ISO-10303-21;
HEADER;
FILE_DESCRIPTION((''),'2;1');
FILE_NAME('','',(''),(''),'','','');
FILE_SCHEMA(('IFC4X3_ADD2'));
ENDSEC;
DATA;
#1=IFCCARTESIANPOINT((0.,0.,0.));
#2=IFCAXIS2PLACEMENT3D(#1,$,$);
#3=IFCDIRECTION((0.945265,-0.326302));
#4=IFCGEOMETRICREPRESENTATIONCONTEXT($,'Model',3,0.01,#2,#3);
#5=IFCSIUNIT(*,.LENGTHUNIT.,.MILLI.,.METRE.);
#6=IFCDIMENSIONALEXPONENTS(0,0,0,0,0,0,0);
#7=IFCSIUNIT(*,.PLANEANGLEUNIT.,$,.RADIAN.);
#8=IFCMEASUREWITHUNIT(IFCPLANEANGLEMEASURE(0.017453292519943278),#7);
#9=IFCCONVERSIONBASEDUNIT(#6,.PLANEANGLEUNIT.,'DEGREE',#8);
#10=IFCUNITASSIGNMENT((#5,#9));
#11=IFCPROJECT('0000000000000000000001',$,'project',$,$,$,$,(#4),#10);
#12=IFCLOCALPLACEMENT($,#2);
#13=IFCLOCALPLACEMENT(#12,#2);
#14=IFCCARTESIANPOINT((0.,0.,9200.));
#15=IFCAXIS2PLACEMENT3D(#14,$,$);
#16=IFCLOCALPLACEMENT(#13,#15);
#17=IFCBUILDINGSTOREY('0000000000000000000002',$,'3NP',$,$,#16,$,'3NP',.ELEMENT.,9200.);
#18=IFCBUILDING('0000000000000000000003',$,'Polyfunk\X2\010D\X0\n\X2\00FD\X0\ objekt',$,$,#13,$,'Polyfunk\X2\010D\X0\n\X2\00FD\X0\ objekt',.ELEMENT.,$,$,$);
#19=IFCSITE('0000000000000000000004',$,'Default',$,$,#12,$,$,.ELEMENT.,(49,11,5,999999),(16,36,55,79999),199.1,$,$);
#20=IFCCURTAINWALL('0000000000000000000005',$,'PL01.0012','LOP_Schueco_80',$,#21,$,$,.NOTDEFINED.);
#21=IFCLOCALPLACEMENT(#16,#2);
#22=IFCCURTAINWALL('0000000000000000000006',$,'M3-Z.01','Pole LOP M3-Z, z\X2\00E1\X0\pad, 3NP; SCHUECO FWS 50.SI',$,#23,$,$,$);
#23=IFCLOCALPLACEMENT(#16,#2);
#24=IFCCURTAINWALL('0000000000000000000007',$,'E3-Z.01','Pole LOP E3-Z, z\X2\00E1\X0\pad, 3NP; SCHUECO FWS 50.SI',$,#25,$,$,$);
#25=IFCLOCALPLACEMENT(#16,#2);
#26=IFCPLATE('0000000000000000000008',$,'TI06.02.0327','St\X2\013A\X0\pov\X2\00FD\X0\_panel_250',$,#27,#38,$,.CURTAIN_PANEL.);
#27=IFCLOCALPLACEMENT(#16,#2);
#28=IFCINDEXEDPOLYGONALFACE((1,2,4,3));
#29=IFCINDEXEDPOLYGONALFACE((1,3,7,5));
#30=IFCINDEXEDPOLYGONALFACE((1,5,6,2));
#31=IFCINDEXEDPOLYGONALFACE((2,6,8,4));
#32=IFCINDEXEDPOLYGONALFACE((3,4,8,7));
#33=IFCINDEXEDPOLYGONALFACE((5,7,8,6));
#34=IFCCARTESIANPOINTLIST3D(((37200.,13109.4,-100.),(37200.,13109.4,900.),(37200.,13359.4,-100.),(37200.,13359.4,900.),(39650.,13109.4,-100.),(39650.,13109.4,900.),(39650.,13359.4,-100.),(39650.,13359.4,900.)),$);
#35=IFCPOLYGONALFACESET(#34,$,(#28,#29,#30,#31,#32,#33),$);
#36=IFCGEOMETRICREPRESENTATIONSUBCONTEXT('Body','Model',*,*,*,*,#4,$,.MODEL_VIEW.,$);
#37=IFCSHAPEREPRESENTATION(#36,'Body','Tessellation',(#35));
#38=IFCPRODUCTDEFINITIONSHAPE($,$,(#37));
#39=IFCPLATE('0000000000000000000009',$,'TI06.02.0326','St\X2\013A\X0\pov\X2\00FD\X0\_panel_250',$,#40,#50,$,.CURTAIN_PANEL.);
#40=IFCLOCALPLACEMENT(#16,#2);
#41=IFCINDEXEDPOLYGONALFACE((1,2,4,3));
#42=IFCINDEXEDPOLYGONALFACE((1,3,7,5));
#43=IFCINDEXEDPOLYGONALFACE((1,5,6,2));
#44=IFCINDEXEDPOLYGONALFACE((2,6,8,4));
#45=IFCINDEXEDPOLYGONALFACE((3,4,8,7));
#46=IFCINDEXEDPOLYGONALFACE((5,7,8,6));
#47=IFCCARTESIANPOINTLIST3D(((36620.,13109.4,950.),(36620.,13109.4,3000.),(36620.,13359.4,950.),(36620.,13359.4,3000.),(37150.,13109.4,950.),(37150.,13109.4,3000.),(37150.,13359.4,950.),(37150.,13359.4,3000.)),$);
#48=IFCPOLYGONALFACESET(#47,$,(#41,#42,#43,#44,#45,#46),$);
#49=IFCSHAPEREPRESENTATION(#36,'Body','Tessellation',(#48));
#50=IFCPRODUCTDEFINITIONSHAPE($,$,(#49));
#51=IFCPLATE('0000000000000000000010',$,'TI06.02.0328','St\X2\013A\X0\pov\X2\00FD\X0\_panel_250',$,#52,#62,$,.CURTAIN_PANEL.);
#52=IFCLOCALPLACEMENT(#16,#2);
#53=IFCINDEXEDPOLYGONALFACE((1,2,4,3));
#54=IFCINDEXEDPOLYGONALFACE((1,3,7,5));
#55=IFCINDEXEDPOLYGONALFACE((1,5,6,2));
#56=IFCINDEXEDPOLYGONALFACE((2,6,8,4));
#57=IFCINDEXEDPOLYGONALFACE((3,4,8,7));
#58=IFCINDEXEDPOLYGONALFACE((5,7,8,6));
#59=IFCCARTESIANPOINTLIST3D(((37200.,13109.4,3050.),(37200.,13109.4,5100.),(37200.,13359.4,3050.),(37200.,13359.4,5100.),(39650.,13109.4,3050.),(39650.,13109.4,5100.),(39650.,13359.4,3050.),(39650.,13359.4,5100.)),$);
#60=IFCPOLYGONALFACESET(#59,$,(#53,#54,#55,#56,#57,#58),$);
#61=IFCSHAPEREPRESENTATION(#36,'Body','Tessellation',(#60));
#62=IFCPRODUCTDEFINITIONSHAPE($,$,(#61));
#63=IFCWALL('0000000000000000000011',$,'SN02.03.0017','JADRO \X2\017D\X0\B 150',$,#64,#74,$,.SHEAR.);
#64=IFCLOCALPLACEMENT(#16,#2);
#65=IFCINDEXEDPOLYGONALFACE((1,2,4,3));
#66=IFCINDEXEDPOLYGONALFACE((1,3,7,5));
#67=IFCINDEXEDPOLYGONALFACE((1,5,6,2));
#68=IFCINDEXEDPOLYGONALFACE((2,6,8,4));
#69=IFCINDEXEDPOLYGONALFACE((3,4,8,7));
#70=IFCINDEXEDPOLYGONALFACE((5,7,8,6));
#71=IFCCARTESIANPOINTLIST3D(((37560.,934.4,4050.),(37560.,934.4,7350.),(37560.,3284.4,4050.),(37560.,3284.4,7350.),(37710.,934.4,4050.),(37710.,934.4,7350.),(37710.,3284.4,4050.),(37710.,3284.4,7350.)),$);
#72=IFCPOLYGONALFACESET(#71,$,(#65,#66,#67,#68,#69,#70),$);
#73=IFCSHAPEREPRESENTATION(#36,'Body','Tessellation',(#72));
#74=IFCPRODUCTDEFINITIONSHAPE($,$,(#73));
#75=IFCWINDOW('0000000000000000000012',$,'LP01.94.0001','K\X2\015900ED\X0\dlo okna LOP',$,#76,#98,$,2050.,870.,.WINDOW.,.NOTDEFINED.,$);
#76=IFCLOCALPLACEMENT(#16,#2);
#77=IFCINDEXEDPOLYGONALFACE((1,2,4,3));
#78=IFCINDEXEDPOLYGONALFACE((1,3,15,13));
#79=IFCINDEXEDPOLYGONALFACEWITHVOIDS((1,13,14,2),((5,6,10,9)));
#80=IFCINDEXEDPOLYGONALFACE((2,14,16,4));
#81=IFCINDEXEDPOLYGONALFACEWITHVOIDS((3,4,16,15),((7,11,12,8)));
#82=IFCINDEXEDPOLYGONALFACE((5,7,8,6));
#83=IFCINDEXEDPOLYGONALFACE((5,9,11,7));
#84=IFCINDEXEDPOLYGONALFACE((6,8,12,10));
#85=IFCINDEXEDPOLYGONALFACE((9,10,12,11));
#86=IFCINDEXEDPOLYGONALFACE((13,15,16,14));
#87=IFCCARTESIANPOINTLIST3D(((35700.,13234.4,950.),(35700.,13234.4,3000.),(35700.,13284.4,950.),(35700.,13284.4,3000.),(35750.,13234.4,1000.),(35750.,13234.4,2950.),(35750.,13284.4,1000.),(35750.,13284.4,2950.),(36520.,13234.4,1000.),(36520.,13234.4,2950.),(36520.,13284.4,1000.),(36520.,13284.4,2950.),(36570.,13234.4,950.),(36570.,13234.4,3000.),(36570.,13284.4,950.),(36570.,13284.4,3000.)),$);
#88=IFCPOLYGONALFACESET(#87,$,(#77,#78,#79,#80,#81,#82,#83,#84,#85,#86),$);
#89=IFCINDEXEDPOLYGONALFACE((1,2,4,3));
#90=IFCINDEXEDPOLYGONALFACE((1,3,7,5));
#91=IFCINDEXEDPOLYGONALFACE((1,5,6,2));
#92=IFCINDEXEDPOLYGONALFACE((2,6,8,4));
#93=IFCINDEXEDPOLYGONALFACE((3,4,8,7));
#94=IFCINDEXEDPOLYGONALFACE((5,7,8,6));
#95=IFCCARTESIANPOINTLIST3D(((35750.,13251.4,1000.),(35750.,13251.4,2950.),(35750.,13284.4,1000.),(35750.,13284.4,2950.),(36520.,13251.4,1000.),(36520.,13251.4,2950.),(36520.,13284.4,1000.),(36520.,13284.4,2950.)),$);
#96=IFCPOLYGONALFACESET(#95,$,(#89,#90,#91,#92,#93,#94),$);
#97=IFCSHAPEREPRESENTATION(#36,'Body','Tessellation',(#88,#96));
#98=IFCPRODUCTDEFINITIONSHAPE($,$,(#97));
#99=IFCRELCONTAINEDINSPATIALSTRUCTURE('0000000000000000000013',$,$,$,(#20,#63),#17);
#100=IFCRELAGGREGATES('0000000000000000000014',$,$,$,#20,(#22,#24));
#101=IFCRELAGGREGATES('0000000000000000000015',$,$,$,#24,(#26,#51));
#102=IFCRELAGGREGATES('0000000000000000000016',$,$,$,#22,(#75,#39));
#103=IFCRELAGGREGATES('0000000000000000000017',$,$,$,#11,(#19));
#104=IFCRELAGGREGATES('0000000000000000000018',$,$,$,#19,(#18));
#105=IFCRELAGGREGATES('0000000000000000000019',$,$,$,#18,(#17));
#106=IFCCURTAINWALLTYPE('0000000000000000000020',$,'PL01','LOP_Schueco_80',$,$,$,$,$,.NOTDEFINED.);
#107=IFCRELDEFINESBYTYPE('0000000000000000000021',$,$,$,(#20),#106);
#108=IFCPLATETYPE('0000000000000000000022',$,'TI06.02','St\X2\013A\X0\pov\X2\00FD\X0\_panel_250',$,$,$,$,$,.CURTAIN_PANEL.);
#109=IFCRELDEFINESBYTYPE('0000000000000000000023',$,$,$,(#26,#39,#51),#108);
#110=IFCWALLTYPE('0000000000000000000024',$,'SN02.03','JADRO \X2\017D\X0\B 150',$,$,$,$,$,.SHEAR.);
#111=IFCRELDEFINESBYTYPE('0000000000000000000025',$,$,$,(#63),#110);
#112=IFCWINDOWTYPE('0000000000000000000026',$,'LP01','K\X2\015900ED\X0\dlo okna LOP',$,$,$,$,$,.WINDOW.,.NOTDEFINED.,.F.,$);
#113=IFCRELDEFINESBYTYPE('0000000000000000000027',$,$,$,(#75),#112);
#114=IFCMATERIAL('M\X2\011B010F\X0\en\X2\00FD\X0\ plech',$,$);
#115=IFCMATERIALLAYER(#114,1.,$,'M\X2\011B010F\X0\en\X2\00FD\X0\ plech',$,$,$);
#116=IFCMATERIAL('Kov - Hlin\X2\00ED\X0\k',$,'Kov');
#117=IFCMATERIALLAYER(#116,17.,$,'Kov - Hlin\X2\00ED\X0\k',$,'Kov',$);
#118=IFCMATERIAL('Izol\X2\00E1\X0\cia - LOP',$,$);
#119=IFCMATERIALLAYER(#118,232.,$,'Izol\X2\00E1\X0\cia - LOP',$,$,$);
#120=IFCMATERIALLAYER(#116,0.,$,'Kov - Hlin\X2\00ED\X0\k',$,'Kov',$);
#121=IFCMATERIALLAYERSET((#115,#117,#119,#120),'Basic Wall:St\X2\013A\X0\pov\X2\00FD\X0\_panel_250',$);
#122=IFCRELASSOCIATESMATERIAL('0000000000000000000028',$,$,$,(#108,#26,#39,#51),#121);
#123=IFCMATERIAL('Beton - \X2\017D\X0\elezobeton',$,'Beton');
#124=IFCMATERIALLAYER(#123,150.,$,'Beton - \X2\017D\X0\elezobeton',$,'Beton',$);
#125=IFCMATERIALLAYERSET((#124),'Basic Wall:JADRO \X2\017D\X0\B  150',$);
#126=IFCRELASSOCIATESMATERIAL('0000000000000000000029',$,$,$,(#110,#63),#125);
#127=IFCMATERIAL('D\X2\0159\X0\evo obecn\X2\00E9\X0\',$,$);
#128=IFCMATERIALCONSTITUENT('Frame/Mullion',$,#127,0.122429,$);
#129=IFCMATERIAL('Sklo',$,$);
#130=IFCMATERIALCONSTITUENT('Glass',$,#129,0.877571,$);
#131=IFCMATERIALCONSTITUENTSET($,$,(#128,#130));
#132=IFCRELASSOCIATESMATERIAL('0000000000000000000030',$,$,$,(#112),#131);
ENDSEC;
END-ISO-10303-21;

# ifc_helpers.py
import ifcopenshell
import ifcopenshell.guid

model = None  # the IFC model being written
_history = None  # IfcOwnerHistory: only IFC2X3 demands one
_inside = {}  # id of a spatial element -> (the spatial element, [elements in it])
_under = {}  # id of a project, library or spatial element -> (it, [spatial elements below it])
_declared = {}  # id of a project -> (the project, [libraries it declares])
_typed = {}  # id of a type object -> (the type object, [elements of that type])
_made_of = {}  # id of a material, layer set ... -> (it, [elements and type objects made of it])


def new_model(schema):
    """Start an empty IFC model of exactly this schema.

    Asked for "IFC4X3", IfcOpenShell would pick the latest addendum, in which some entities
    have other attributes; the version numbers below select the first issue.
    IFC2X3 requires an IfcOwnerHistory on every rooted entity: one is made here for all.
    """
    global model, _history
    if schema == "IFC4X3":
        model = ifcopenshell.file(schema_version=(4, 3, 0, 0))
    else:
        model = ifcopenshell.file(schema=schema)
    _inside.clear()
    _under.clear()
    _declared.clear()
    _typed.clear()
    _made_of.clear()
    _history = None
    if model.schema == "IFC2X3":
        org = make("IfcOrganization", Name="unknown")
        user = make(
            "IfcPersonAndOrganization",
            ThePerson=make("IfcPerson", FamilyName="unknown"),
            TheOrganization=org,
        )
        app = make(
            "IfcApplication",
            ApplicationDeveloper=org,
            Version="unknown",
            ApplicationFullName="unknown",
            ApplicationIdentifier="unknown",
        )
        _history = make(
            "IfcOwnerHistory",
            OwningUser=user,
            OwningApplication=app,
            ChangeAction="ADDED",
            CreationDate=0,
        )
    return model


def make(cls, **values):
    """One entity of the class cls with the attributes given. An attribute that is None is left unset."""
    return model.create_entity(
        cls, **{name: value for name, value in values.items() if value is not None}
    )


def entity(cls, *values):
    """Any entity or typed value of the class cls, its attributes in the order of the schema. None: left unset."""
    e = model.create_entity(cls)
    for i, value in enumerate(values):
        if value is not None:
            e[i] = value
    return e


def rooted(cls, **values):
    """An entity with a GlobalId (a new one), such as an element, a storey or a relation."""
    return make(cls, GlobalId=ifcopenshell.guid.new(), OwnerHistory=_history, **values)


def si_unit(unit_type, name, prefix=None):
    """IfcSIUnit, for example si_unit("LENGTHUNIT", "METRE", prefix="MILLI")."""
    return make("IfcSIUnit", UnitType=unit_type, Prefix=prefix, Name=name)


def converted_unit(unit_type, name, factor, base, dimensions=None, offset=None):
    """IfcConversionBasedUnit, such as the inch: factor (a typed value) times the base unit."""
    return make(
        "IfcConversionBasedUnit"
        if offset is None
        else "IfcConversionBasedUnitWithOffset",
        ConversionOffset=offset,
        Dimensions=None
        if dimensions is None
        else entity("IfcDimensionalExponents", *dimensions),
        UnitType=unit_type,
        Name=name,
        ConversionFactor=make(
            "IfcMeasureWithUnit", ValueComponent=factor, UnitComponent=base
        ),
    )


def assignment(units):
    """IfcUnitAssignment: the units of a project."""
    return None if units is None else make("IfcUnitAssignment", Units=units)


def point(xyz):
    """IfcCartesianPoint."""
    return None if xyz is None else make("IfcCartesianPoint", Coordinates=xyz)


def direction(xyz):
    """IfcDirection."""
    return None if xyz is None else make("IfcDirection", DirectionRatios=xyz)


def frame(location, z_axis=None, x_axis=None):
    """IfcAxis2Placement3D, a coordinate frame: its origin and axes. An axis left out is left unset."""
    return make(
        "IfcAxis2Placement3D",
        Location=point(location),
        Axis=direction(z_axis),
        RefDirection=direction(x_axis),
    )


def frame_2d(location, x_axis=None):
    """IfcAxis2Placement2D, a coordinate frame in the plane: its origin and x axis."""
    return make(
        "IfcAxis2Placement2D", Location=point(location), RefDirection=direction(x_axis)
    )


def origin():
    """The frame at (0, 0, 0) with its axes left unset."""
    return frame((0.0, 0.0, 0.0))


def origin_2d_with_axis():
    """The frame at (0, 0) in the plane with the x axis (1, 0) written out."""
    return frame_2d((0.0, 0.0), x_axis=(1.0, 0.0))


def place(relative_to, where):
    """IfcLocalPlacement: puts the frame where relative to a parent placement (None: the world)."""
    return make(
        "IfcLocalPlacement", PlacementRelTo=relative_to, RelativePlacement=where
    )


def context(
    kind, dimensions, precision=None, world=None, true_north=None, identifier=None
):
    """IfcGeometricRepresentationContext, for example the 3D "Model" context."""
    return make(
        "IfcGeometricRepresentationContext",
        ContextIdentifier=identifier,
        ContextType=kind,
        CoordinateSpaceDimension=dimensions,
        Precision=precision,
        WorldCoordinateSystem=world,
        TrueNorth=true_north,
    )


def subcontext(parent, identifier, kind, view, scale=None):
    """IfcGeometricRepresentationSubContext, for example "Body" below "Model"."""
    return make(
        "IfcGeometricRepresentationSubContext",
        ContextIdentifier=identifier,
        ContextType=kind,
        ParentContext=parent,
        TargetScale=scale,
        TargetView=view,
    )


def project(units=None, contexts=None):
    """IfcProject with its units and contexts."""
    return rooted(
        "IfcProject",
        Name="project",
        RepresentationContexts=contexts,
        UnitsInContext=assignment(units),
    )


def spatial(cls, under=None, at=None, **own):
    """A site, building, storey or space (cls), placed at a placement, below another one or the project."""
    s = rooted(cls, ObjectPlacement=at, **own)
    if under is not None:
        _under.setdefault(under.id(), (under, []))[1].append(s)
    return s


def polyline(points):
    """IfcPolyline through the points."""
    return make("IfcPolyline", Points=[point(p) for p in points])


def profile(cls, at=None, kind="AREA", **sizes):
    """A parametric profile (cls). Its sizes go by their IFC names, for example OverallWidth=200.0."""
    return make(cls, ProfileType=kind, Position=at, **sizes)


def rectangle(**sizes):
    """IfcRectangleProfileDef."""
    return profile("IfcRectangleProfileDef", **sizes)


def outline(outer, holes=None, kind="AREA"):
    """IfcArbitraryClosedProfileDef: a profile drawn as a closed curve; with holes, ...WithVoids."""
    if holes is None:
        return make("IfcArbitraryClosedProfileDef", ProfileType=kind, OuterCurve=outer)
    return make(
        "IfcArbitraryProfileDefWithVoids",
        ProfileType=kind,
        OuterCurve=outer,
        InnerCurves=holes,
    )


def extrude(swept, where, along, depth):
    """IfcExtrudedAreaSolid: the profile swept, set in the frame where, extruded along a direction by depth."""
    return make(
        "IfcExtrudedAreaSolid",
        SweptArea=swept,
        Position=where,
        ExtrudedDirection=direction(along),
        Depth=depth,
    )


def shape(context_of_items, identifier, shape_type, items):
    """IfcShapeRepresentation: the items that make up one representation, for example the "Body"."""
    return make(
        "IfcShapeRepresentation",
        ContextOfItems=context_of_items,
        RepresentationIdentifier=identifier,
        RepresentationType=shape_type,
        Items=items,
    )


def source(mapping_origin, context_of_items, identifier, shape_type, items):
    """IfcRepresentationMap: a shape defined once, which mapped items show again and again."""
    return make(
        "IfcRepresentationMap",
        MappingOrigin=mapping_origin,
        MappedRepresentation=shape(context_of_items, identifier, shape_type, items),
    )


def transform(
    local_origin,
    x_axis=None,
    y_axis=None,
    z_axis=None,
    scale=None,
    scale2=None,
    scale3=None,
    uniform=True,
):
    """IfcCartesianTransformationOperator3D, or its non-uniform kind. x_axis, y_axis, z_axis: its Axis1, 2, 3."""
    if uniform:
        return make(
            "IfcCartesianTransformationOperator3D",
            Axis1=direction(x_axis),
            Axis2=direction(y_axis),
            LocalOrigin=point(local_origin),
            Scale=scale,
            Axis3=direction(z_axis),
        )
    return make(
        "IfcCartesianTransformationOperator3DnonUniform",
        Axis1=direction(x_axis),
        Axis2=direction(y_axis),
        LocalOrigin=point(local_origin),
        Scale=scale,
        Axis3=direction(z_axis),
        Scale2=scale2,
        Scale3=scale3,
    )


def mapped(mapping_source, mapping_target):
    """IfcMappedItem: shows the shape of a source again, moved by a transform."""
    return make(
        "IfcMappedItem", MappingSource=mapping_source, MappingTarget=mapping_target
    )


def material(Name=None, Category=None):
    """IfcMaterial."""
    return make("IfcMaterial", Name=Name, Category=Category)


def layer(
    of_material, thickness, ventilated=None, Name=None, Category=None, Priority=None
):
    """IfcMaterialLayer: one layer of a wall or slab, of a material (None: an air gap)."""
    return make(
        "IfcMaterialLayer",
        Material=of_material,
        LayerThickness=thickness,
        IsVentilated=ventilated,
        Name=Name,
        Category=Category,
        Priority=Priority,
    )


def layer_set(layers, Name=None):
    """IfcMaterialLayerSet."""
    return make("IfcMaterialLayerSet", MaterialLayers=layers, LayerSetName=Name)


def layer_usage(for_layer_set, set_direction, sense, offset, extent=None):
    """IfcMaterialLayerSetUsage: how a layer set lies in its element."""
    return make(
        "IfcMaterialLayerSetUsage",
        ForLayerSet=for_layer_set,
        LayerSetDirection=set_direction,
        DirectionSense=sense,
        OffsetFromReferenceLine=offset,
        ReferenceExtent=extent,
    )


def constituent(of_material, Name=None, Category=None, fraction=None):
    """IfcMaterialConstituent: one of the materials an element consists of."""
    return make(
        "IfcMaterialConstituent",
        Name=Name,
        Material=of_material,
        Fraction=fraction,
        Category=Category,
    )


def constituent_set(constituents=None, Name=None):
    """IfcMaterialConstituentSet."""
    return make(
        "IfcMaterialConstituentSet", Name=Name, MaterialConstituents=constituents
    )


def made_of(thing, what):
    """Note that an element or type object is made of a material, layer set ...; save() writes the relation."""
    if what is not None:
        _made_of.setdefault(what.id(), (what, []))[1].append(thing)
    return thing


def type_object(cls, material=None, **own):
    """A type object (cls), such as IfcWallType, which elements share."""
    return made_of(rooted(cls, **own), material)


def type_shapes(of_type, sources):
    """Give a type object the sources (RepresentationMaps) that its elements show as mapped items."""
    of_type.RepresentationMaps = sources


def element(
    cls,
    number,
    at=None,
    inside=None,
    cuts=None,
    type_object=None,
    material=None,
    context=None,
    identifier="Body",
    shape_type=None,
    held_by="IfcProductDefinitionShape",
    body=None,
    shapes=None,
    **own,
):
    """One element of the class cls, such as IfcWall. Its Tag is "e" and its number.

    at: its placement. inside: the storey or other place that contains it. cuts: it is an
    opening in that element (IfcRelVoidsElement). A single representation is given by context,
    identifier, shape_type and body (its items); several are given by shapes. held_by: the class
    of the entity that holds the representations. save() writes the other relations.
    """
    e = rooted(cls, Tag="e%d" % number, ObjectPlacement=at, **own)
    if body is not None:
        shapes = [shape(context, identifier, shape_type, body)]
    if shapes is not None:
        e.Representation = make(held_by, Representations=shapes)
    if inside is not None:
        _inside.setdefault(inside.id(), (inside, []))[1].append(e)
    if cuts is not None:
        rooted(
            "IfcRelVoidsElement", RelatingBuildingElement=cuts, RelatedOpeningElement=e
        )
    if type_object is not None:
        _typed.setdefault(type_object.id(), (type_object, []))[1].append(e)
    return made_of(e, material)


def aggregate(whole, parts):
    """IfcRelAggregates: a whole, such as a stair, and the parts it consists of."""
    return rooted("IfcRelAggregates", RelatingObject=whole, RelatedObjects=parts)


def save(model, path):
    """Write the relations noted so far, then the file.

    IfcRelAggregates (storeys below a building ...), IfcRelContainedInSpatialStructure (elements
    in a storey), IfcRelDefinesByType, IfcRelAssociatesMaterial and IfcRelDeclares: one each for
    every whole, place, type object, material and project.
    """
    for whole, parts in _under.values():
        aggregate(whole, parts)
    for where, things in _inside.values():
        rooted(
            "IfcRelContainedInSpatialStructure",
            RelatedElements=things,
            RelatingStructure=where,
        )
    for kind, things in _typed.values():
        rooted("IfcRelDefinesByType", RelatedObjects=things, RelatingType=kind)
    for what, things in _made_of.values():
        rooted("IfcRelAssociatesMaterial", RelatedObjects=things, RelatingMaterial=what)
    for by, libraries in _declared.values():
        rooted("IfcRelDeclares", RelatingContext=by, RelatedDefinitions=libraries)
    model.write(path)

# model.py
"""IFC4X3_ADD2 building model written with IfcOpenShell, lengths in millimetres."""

from ifc_helpers import new_model, entity, si_unit, converted_unit, direction, frame, frame_2d, origin, origin_2d_with_axis, place, context, subcontext, project, spatial, polyline, rectangle, outline, extrude, source, transform, mapped, material, layer, layer_set, layer_usage, constituent, constituent_set, type_object, type_shapes, element, aggregate, save


model = new_model("IFC4X3_ADD2")

# Units and contexts
model_context = context("Model", 3, precision=0.01, world=origin(), true_north=direction((0.945265, -0.326302)))
body_context = subcontext(model_context, "Body", "Model", "MODEL_VIEW")
ifc_project = project(units=[si_unit("LENGTHUNIT", "METRE", prefix="MILLI"), converted_unit("PLANEANGLEUNIT", "DEGREE", entity("IfcPlaneAngleMeasure", 0.017453292519943278), si_unit("PLANEANGLEUNIT", "RADIAN"), dimensions=[0, 0, 0, 0, 0, 0, 0])], contexts=[model_context])

# Site, building, storey
site_placement = place(None, origin())
site = spatial("IfcSite", under=ifc_project, at=site_placement, Name="Default", CompositionType="ELEMENT", RefLatitude=(49, 11, 5, 999999), RefLongitude=(16, 36, 55, 79999), RefElevation=199.1)
building_placement = place(site_placement, origin())
building = spatial("IfcBuilding", under=site, at=building_placement, Name="Polyfunkčný objekt", LongName="Polyfunkčný objekt", CompositionType="ELEMENT")
storey_placement = place(building_placement, frame((0.0, 0.0, 9200.0)))
storey = spatial("IfcBuildingStorey", under=building, at=storey_placement, Name="3NP", LongName="3NP", CompositionType="ELEMENT", Elevation=9200.0)

# Curtain walls, plates
curtain_wall_type = type_object("IfcCurtainWallType", Name="PL01", Description="LOP_Schueco_80", PredefinedType="NOTDEFINED")
curtain_wall_1_placement = place(storey_placement, frame((0.0, 0.0, -9200.0)))
curtain_wall_1 = element("IfcCurtainWall", 1, at=curtain_wall_1_placement, inside=storey, type_object=curtain_wall_type, Name="PL01.0012", Description="LOP_Schueco_80", PredefinedType="NOTDEFINED")
curtain_wall_2 = element("IfcCurtainWall", 2, Name="M3-Z.01", Description="Pole LOP M3-Z, západ, 3NP; SCHUECO FWS 50.SI")
curtain_wall_3 = element("IfcCurtainWall", 3, Name="E3-Z.01", Description="Pole LOP E3-Z, západ, 3NP; SCHUECO FWS 50.SI")
aggregate(curtain_wall_1, [curtain_wall_2, curtain_wall_3])
ifc_material_1 = material(Name="Měďený plech")
ifc_layer_1 = layer(ifc_material_1, 1.0, Name="Měďený plech")
ifc_material_2 = material(Name="Kov - Hliník", Category="Kov")
ifc_layer_2 = layer(ifc_material_2, 17.0, Name="Kov - Hliník", Category="Kov")
ifc_material_3 = material(Name="Izolácia - LOP")
ifc_layer_3 = layer(ifc_material_3, 232.0, Name="Izolácia - LOP")
ifc_layer_4 = layer(ifc_material_2, 0.0, Name="Kov - Hliník", Category="Kov")
ifc_layer_set_1 = layer_set([ifc_layer_1, ifc_layer_2, ifc_layer_3, ifc_layer_4], Name="Basic Wall:Stĺpový_panel_250")
ifc_layer_usage_1 = layer_usage(ifc_layer_set_1, "AXIS2", "NEGATIVE", 125.0)
plate_type = type_object("IfcPlateType", Name="TI06.02", Description="Stĺpový_panel_250", PredefinedType="CURTAIN_PANEL", material=ifc_layer_set_1)
plate_1_placement = place(storey_placement, frame((37200.0, 13234.4, -100.0)))
plate_1 = element("IfcPlate", 4, at=plate_1_placement, type_object=plate_type, material=ifc_layer_usage_1, Name="TI06.02.0327", Description="Stĺpový_panel_250", PredefinedType="CURTAIN_PANEL", context=body_context, shape_type="SweptSolid", body=[
    extrude(rectangle(XDim=250.0, YDim=2450.0, at=frame_2d((0.0, 0.0), x_axis=(1.0, 0.0))), frame((1225.0, 0.0, 0.0), z_axis=(0.0, 0.0, 1.0), x_axis=(0.0, 1.0, 0.0)), (0.0, 0.0, 1.0), 1000.0),
])
ifc_layer_usage_2 = layer_usage(ifc_layer_set_1, "AXIS2", "NEGATIVE", 125.0)
plate_2_placement = place(storey_placement, frame((36620.0, 13234.4, 950.0)))
plate_2 = element("IfcPlate", 5, at=plate_2_placement, type_object=plate_type, material=ifc_layer_usage_2, Name="TI06.02.0326", Description="Stĺpový_panel_250", PredefinedType="CURTAIN_PANEL", context=body_context, shape_type="SweptSolid", body=[
    extrude(rectangle(XDim=250.0, YDim=530.0, at=frame_2d((0.0, 0.0), x_axis=(1.0, 0.0))), frame((265.0, 0.0, 0.0), z_axis=(0.0, 0.0, 1.0), x_axis=(0.0, 1.0, 0.0)), (0.0, 0.0, 1.0), 2050.0),
])
ifc_layer_usage_3 = layer_usage(ifc_layer_set_1, "AXIS2", "NEGATIVE", 125.0)
plate_3_placement = place(storey_placement, frame((37200.0, 13234.4, 3050.0)))
plate_3 = element("IfcPlate", 6, at=plate_3_placement, type_object=plate_type, material=ifc_layer_usage_3, Name="TI06.02.0328", Description="Stĺpový_panel_250", PredefinedType="CURTAIN_PANEL", context=body_context, shape_type="SweptSolid", body=[
    extrude(rectangle(XDim=250.0, YDim=2450.0, at=frame_2d((0.0, 0.0), x_axis=(1.0, 0.0))), frame((1225.0, 0.0, 0.0), z_axis=(0.0, 0.0, 1.0), x_axis=(0.0, 1.0, 0.0)), (0.0, 0.0, 1.0), 2050.0),
])
aggregate(curtain_wall_3, [plate_1, plate_3])

# Wall
ifc_material_4 = material(Name="Beton - Železobeton", Category="Beton")
ifc_layer_5 = layer(ifc_material_4, 150.0, Name="Beton - Železobeton", Category="Beton")
ifc_layer_set_2 = layer_set([ifc_layer_5], Name="Basic Wall:JADRO ŽB  150")
wall_type = type_object("IfcWallType", Name="SN02.03", Description="JADRO ŽB 150", PredefinedType="SHEAR", material=ifc_layer_set_2)
wall_placement = place(storey_placement, frame((37635.0, 3284.4, 4050.0), z_axis=(0.0, 0.0, 1.0), x_axis=(0.0, -1.0, 0.0)))
element("IfcWall", 7, at=wall_placement, inside=storey, type_object=wall_type, material=ifc_layer_set_2, Name="SN02.03.0017", Description="JADRO ŽB 150", PredefinedType="SHEAR", context=body_context, shape_type="SweptSolid", body=[
    extrude(rectangle(XDim=2350.0, YDim=150.0, at=frame_2d((1175.0, 0.0), x_axis=(-1.0, 0.0))), origin(), (0.0, 0.0, 1.0), 3300.0),
])

# Window
ifc_material_5 = material(Name="Dřevo obecné")
ifc_constituent_1 = constituent(ifc_material_5, Name="Frame/Mullion", fraction=0.122429)
ifc_material_6 = material(Name="Sklo")
ifc_constituent_2 = constituent(ifc_material_6, Name="Glass", fraction=0.877571)
ifc_constituent_set = constituent_set(constituents=[ifc_constituent_1, ifc_constituent_2])
window_type = type_object("IfcWindowType", Name="LP01", Description="Křídlo okna LOP", ParameterTakesPrecedence=False, PartitioningType="NOTDEFINED", PredefinedType="WINDOW", material=ifc_constituent_set)
shared_shape_1 = source(origin(), body_context, "Body", "SweptSolid", [
    extrude(outline(polyline([(-1025.0, -435.0), (1025.0, -435.0), (1025.0, 435.0), (-1025.0, 435.0), (-1025.0, -435.0)]), holes=[polyline([(-975.0, -385.0), (-975.0, 385.0), (975.0, 385.0), (975.0, -385.0), (-975.0, -385.0)])]), frame((0.0, 0.0, 1025.0), z_axis=(0.0, 1.0, 0.0), x_axis=(0.0, 0.0, -1.0)), (0.0, 0.0, 1.0), 50.0),
    extrude(rectangle(XDim=33.0, YDim=770.0, at=origin_2d_with_axis()), frame((0.0, 33.5, 50.0), z_axis=(0.0, 0.0, 1.0), x_axis=(0.0, -1.0, 0.0)), (0.0, 0.0, 1.0), 1950.0),
])
type_shapes(window_type, [shared_shape_1])
window_placement = place(curtain_wall_1_placement, frame((36135.0, 13234.4, 10150.0)))
window = element("IfcWindow", 8, at=window_placement, type_object=window_type, Name="LP01.94.0001", Description="Křídlo okna LOP", OverallHeight=2050.0, OverallWidth=870.0, PartitioningType="NOTDEFINED", PredefinedType="WINDOW", context=body_context, shape_type="MappedRepresentation", body=[
    mapped(shared_shape_1, transform((0.0, 0.0, 0.0), scale=1.0)),
])
aggregate(curtain_wall_2, [window, plate_2])

save(model, "model.ifc")
